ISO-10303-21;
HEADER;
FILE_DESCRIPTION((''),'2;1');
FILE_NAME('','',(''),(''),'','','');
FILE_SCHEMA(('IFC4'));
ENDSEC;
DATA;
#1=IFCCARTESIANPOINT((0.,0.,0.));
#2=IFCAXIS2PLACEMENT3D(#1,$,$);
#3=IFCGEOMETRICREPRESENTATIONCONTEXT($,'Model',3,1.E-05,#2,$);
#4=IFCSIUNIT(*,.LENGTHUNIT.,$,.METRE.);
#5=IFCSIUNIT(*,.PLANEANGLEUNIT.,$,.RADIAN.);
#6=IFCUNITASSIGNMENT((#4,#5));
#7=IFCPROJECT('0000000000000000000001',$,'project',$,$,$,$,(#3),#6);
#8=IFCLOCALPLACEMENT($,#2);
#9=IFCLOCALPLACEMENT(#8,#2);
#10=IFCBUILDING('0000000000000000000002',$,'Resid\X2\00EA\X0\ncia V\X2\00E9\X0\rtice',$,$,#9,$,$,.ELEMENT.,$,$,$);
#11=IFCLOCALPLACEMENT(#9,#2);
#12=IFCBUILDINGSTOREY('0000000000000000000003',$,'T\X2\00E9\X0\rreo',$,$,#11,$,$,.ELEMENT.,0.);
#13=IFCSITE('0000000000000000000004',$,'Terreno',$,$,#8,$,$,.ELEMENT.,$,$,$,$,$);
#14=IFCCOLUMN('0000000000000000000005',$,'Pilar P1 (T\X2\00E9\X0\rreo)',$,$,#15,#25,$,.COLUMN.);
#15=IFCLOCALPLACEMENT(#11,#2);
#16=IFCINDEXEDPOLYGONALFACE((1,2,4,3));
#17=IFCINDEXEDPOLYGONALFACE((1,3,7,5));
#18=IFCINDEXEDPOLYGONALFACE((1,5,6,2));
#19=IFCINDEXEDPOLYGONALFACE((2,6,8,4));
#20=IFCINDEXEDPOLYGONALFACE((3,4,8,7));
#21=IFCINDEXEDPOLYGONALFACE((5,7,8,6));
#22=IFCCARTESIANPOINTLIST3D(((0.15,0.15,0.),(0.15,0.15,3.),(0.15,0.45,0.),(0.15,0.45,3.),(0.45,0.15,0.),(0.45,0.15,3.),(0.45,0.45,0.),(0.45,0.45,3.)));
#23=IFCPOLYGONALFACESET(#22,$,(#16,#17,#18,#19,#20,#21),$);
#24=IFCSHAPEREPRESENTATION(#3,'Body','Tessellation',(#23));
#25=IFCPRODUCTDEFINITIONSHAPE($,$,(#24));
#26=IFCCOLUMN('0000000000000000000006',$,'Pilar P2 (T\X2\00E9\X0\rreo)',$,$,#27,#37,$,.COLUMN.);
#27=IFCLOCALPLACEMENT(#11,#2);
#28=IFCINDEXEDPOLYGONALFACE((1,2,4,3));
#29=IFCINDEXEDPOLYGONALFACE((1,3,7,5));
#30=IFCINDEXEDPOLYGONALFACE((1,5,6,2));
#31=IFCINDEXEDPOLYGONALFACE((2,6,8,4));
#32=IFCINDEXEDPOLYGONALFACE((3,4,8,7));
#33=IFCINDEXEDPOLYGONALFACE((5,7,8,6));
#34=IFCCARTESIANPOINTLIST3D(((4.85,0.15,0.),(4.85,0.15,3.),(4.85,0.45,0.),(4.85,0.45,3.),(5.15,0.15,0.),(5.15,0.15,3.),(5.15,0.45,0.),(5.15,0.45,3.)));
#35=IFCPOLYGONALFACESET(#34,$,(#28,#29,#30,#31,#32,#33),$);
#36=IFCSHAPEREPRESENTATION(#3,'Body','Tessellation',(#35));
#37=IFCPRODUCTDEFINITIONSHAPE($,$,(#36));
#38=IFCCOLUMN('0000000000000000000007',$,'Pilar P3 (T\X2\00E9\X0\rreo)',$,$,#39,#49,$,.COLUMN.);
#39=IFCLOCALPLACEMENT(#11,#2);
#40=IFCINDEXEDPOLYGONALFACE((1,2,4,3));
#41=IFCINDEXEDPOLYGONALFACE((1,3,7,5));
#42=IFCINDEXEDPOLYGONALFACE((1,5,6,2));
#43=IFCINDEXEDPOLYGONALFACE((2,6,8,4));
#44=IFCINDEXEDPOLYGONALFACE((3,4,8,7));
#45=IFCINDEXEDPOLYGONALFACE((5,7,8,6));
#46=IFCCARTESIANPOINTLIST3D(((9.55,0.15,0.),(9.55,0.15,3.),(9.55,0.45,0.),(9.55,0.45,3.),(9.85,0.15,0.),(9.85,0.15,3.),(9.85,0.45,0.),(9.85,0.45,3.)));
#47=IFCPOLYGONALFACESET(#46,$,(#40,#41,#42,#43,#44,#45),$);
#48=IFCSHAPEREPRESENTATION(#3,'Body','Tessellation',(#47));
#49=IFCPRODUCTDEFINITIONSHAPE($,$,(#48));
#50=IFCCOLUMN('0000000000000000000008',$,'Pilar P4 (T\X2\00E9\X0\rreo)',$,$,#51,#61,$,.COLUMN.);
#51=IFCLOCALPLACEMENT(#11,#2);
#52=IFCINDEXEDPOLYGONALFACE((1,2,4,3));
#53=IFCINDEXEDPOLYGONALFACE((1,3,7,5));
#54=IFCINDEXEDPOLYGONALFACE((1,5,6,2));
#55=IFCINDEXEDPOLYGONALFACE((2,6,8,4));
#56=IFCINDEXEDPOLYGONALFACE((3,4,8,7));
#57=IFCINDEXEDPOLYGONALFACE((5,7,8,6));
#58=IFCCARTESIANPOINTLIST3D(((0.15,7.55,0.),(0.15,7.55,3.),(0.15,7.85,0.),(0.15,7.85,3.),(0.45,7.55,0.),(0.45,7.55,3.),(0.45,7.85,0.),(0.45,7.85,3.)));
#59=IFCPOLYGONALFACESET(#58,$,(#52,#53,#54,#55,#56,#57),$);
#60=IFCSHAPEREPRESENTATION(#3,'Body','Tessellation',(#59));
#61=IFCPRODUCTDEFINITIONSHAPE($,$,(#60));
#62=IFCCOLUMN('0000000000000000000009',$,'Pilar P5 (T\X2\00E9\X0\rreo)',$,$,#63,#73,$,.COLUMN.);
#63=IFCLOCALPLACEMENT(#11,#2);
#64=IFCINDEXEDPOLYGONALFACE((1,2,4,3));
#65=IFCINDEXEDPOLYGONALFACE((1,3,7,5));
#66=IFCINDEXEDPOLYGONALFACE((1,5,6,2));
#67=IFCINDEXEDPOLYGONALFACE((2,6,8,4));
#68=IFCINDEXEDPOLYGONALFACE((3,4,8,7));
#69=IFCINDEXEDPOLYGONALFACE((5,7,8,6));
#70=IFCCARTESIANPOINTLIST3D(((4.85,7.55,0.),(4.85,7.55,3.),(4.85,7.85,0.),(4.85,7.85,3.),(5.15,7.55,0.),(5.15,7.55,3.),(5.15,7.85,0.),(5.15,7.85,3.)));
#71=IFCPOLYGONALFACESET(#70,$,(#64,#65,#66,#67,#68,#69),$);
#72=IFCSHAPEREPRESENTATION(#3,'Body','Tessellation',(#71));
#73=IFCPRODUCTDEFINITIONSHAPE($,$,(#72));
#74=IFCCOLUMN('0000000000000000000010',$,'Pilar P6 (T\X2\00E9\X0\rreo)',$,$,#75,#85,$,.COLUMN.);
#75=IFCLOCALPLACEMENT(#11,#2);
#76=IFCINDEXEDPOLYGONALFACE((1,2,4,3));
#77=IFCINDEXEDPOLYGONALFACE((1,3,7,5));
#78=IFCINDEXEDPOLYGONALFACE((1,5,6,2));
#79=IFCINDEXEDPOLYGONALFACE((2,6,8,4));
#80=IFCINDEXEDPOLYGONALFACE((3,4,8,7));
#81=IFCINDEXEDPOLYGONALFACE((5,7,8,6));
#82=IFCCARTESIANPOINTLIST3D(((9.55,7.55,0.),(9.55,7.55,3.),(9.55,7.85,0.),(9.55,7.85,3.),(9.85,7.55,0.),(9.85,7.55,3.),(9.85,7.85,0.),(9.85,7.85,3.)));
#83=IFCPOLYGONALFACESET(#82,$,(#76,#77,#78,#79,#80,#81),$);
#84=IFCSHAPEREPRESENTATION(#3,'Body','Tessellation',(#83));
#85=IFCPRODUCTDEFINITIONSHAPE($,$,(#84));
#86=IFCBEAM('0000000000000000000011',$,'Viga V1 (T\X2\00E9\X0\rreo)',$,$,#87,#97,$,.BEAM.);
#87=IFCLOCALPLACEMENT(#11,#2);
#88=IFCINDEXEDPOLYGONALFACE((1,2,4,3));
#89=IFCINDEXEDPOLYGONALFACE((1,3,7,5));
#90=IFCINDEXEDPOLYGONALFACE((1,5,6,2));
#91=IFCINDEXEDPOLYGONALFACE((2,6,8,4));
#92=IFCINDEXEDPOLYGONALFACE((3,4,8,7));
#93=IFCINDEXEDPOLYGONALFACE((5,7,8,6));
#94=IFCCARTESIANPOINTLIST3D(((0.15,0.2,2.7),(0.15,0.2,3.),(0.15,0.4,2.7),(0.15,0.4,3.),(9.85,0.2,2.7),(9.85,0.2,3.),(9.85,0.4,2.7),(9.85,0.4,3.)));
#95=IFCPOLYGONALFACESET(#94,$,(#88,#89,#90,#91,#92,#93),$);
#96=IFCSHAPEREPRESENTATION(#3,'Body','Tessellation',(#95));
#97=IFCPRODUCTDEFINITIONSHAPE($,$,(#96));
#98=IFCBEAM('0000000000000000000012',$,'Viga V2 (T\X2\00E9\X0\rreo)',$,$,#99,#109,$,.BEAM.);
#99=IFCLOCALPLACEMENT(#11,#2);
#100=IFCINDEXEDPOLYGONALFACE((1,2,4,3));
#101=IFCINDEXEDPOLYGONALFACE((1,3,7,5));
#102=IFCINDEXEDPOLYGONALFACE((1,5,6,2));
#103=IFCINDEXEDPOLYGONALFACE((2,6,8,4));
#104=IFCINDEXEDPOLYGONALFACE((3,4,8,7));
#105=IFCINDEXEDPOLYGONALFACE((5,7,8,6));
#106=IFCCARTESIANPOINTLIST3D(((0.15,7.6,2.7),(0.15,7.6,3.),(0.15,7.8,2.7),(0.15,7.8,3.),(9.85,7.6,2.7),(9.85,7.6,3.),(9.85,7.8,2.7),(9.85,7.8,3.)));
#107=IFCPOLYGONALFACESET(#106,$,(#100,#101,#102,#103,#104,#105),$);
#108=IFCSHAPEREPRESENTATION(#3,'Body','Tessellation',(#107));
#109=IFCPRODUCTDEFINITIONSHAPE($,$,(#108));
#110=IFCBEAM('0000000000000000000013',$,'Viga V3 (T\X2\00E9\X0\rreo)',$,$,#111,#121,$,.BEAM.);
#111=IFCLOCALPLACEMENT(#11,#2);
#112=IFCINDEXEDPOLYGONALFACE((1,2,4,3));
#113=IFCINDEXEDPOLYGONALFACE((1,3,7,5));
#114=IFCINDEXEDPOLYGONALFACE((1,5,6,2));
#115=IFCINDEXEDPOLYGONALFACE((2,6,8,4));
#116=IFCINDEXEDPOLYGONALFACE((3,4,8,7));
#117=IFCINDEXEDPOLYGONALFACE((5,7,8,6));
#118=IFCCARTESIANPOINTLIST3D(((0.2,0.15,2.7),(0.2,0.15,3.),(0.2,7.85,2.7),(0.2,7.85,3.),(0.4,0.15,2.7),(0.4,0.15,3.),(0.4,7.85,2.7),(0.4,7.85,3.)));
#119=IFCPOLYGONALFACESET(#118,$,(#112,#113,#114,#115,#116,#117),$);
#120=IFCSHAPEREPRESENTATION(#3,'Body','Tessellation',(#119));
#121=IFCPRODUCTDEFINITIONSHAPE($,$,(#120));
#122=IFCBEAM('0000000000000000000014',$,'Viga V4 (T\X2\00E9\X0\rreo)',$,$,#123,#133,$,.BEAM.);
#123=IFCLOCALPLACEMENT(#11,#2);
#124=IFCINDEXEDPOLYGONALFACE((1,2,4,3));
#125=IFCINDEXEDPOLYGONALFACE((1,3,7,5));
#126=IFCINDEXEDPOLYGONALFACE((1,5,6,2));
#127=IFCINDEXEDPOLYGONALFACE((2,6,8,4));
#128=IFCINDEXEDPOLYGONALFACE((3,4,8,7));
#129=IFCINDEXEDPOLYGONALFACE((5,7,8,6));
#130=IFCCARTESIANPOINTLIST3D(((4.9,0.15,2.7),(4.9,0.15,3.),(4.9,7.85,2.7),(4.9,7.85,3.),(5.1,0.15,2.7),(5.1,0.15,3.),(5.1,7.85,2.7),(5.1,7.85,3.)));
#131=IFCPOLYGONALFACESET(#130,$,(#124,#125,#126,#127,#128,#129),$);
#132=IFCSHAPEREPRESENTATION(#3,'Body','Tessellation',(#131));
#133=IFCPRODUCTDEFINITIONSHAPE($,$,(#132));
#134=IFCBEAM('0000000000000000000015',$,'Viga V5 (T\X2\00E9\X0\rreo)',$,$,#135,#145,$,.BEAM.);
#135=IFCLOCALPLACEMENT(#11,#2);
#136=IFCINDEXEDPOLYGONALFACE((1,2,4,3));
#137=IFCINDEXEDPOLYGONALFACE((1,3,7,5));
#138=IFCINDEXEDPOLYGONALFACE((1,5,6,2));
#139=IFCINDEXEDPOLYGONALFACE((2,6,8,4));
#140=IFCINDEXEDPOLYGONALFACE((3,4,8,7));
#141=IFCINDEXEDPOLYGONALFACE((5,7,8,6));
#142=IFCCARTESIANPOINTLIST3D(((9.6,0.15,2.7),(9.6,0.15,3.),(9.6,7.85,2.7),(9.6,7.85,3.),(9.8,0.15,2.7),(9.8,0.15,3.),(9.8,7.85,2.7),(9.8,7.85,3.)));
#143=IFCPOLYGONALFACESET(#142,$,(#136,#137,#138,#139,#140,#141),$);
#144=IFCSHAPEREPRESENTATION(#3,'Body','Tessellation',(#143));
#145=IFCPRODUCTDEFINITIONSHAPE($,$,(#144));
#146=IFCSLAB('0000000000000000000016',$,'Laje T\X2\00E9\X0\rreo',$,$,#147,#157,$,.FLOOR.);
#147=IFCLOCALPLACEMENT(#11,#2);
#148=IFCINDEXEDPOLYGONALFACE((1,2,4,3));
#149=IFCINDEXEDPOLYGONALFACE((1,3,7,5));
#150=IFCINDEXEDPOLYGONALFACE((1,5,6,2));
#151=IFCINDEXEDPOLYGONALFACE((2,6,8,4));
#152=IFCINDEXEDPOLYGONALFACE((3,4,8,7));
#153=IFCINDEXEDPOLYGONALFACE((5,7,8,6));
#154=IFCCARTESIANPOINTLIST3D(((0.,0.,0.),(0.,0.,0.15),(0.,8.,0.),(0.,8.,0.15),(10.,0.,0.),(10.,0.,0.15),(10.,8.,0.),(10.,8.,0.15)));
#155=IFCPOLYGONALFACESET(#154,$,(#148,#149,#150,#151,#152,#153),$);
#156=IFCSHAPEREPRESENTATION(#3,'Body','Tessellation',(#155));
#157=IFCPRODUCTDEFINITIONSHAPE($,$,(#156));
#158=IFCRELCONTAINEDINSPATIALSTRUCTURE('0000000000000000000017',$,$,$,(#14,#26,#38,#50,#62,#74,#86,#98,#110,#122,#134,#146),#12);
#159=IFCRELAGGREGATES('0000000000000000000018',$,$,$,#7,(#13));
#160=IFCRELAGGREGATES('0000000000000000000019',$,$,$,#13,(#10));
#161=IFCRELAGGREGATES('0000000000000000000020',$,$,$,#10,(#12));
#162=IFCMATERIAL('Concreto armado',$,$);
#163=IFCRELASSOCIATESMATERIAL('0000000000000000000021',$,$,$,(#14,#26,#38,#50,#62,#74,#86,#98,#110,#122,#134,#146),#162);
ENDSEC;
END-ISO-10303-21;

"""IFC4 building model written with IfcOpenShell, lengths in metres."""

from ifc_helpers import new_model, si_unit, frame, frame_2d, origin, place, context, project, spatial, rectangle, extrude, material, element, save


model = new_model("IFC4")

# Units and contexts
model_context = context("Model", 3, precision=1e-05, world=origin())
ifc_project = project(units=[si_unit("LENGTHUNIT", "METRE"), si_unit("PLANEANGLEUNIT", "RADIAN")], contexts=[model_context])

# Site, building, storey
site_placement = place(None, origin())
site = spatial("IfcSite", under=ifc_project, at=site_placement, Name="Terreno", CompositionType="ELEMENT")
building_placement = place(site_placement, origin())
building = spatial("IfcBuilding", under=site, at=building_placement, Name="Residência Vértice", CompositionType="ELEMENT")
storey_placement = place(building_placement, origin())
storey = spatial("IfcBuildingStorey", under=building, at=storey_placement, Name="Térreo", CompositionType="ELEMENT", Elevation=0.0)

# Columns
ifc_material_1 = material(Name="Concreto armado")
column_1_placement = place(storey_placement, origin())
element("IfcColumn", 1, at=column_1_placement, inside=storey, material=ifc_material_1, Name="Pilar P1 (Térreo)", PredefinedType="COLUMN", context=model_context, shape_type="SweptSolid", body=[
    extrude(rectangle(XDim=0.3, YDim=0.3, at=frame_2d((0.3, 0.3))), origin(), (0.0, 0.0, 1.0), 3.0),
])
column_2_placement = place(storey_placement, origin())
element("IfcColumn", 2, at=column_2_placement, inside=storey, material=ifc_material_1, Name="Pilar P2 (Térreo)", PredefinedType="COLUMN", context=model_context, shape_type="SweptSolid", body=[
    extrude(rectangle(XDim=0.3, YDim=0.3, at=frame_2d((5.0, 0.3))), origin(), (0.0, 0.0, 1.0), 3.0),
])
column_3_placement = place(storey_placement, origin())
element("IfcColumn", 3, at=column_3_placement, inside=storey, material=ifc_material_1, Name="Pilar P3 (Térreo)", PredefinedType="COLUMN", context=model_context, shape_type="SweptSolid", body=[
    extrude(rectangle(XDim=0.3, YDim=0.3, at=frame_2d((9.7, 0.3))), origin(), (0.0, 0.0, 1.0), 3.0),
])
column_4_placement = place(storey_placement, origin())
element("IfcColumn", 4, at=column_4_placement, inside=storey, material=ifc_material_1, Name="Pilar P4 (Térreo)", PredefinedType="COLUMN", context=model_context, shape_type="SweptSolid", body=[
    extrude(rectangle(XDim=0.3, YDim=0.3, at=frame_2d((0.3, 7.7))), origin(), (0.0, 0.0, 1.0), 3.0),
])
column_5_placement = place(storey_placement, origin())
element("IfcColumn", 5, at=column_5_placement, inside=storey, material=ifc_material_1, Name="Pilar P5 (Térreo)", PredefinedType="COLUMN", context=model_context, shape_type="SweptSolid", body=[
    extrude(rectangle(XDim=0.3, YDim=0.3, at=frame_2d((5.0, 7.7))), origin(), (0.0, 0.0, 1.0), 3.0),
])
column_6_placement = place(storey_placement, origin())
element("IfcColumn", 6, at=column_6_placement, inside=storey, material=ifc_material_1, Name="Pilar P6 (Térreo)", PredefinedType="COLUMN", context=model_context, shape_type="SweptSolid", body=[
    extrude(rectangle(XDim=0.3, YDim=0.3, at=frame_2d((9.7, 7.7))), origin(), (0.0, 0.0, 1.0), 3.0),
])

# Beams
beam_1_placement = place(storey_placement, origin())
element("IfcBeam", 7, at=beam_1_placement, inside=storey, material=ifc_material_1, Name="Viga V1 (Térreo)", PredefinedType="BEAM", context=model_context, shape_type="SweptSolid", body=[
    extrude(rectangle(XDim=9.7, YDim=0.2, at=frame_2d((5.0, 0.3))), frame((0.0, 0.0, 2.7)), (0.0, 0.0, 1.0), 0.3),
])
beam_2_placement = place(storey_placement, origin())
element("IfcBeam", 8, at=beam_2_placement, inside=storey, material=ifc_material_1, Name="Viga V2 (Térreo)", PredefinedType="BEAM", context=model_context, shape_type="SweptSolid", body=[
    extrude(rectangle(XDim=9.7, YDim=0.2, at=frame_2d((5.0, 7.7))), frame((0.0, 0.0, 2.7)), (0.0, 0.0, 1.0), 0.3),
])
beam_3_placement = place(storey_placement, origin())
element("IfcBeam", 9, at=beam_3_placement, inside=storey, material=ifc_material_1, Name="Viga V3 (Térreo)", PredefinedType="BEAM", context=model_context, shape_type="SweptSolid", body=[
    extrude(rectangle(XDim=0.2, YDim=7.7, at=frame_2d((0.3, 4.0))), frame((0.0, 0.0, 2.7)), (0.0, 0.0, 1.0), 0.3),
])
beam_4_placement = place(storey_placement, origin())
element("IfcBeam", 10, at=beam_4_placement, inside=storey, material=ifc_material_1, Name="Viga V4 (Térreo)", PredefinedType="BEAM", context=model_context, shape_type="SweptSolid", body=[
    extrude(rectangle(XDim=0.2, YDim=7.7, at=frame_2d((5.0, 4.0))), frame((0.0, 0.0, 2.7)), (0.0, 0.0, 1.0), 0.3),
])
beam_5_placement = place(storey_placement, origin())
element("IfcBeam", 11, at=beam_5_placement, inside=storey, material=ifc_material_1, Name="Viga V5 (Térreo)", PredefinedType="BEAM", context=model_context, shape_type="SweptSolid", body=[
    extrude(rectangle(XDim=0.2, YDim=7.7, at=frame_2d((9.7, 4.0))), frame((0.0, 0.0, 2.7)), (0.0, 0.0, 1.0), 0.3),
])

# Slab
slab_placement = place(storey_placement, origin())
element("IfcSlab", 12, at=slab_placement, inside=storey, material=ifc_material_1, Name="Laje Térreo", PredefinedType="FLOOR", context=model_context, shape_type="SweptSolid", body=[
    extrude(rectangle(XDim=10.0, YDim=8.0, at=frame_2d((5.0, 4.0))), origin(), (0.0, 0.0, 1.0), 0.15),
])

save(model, "model.ifc")
